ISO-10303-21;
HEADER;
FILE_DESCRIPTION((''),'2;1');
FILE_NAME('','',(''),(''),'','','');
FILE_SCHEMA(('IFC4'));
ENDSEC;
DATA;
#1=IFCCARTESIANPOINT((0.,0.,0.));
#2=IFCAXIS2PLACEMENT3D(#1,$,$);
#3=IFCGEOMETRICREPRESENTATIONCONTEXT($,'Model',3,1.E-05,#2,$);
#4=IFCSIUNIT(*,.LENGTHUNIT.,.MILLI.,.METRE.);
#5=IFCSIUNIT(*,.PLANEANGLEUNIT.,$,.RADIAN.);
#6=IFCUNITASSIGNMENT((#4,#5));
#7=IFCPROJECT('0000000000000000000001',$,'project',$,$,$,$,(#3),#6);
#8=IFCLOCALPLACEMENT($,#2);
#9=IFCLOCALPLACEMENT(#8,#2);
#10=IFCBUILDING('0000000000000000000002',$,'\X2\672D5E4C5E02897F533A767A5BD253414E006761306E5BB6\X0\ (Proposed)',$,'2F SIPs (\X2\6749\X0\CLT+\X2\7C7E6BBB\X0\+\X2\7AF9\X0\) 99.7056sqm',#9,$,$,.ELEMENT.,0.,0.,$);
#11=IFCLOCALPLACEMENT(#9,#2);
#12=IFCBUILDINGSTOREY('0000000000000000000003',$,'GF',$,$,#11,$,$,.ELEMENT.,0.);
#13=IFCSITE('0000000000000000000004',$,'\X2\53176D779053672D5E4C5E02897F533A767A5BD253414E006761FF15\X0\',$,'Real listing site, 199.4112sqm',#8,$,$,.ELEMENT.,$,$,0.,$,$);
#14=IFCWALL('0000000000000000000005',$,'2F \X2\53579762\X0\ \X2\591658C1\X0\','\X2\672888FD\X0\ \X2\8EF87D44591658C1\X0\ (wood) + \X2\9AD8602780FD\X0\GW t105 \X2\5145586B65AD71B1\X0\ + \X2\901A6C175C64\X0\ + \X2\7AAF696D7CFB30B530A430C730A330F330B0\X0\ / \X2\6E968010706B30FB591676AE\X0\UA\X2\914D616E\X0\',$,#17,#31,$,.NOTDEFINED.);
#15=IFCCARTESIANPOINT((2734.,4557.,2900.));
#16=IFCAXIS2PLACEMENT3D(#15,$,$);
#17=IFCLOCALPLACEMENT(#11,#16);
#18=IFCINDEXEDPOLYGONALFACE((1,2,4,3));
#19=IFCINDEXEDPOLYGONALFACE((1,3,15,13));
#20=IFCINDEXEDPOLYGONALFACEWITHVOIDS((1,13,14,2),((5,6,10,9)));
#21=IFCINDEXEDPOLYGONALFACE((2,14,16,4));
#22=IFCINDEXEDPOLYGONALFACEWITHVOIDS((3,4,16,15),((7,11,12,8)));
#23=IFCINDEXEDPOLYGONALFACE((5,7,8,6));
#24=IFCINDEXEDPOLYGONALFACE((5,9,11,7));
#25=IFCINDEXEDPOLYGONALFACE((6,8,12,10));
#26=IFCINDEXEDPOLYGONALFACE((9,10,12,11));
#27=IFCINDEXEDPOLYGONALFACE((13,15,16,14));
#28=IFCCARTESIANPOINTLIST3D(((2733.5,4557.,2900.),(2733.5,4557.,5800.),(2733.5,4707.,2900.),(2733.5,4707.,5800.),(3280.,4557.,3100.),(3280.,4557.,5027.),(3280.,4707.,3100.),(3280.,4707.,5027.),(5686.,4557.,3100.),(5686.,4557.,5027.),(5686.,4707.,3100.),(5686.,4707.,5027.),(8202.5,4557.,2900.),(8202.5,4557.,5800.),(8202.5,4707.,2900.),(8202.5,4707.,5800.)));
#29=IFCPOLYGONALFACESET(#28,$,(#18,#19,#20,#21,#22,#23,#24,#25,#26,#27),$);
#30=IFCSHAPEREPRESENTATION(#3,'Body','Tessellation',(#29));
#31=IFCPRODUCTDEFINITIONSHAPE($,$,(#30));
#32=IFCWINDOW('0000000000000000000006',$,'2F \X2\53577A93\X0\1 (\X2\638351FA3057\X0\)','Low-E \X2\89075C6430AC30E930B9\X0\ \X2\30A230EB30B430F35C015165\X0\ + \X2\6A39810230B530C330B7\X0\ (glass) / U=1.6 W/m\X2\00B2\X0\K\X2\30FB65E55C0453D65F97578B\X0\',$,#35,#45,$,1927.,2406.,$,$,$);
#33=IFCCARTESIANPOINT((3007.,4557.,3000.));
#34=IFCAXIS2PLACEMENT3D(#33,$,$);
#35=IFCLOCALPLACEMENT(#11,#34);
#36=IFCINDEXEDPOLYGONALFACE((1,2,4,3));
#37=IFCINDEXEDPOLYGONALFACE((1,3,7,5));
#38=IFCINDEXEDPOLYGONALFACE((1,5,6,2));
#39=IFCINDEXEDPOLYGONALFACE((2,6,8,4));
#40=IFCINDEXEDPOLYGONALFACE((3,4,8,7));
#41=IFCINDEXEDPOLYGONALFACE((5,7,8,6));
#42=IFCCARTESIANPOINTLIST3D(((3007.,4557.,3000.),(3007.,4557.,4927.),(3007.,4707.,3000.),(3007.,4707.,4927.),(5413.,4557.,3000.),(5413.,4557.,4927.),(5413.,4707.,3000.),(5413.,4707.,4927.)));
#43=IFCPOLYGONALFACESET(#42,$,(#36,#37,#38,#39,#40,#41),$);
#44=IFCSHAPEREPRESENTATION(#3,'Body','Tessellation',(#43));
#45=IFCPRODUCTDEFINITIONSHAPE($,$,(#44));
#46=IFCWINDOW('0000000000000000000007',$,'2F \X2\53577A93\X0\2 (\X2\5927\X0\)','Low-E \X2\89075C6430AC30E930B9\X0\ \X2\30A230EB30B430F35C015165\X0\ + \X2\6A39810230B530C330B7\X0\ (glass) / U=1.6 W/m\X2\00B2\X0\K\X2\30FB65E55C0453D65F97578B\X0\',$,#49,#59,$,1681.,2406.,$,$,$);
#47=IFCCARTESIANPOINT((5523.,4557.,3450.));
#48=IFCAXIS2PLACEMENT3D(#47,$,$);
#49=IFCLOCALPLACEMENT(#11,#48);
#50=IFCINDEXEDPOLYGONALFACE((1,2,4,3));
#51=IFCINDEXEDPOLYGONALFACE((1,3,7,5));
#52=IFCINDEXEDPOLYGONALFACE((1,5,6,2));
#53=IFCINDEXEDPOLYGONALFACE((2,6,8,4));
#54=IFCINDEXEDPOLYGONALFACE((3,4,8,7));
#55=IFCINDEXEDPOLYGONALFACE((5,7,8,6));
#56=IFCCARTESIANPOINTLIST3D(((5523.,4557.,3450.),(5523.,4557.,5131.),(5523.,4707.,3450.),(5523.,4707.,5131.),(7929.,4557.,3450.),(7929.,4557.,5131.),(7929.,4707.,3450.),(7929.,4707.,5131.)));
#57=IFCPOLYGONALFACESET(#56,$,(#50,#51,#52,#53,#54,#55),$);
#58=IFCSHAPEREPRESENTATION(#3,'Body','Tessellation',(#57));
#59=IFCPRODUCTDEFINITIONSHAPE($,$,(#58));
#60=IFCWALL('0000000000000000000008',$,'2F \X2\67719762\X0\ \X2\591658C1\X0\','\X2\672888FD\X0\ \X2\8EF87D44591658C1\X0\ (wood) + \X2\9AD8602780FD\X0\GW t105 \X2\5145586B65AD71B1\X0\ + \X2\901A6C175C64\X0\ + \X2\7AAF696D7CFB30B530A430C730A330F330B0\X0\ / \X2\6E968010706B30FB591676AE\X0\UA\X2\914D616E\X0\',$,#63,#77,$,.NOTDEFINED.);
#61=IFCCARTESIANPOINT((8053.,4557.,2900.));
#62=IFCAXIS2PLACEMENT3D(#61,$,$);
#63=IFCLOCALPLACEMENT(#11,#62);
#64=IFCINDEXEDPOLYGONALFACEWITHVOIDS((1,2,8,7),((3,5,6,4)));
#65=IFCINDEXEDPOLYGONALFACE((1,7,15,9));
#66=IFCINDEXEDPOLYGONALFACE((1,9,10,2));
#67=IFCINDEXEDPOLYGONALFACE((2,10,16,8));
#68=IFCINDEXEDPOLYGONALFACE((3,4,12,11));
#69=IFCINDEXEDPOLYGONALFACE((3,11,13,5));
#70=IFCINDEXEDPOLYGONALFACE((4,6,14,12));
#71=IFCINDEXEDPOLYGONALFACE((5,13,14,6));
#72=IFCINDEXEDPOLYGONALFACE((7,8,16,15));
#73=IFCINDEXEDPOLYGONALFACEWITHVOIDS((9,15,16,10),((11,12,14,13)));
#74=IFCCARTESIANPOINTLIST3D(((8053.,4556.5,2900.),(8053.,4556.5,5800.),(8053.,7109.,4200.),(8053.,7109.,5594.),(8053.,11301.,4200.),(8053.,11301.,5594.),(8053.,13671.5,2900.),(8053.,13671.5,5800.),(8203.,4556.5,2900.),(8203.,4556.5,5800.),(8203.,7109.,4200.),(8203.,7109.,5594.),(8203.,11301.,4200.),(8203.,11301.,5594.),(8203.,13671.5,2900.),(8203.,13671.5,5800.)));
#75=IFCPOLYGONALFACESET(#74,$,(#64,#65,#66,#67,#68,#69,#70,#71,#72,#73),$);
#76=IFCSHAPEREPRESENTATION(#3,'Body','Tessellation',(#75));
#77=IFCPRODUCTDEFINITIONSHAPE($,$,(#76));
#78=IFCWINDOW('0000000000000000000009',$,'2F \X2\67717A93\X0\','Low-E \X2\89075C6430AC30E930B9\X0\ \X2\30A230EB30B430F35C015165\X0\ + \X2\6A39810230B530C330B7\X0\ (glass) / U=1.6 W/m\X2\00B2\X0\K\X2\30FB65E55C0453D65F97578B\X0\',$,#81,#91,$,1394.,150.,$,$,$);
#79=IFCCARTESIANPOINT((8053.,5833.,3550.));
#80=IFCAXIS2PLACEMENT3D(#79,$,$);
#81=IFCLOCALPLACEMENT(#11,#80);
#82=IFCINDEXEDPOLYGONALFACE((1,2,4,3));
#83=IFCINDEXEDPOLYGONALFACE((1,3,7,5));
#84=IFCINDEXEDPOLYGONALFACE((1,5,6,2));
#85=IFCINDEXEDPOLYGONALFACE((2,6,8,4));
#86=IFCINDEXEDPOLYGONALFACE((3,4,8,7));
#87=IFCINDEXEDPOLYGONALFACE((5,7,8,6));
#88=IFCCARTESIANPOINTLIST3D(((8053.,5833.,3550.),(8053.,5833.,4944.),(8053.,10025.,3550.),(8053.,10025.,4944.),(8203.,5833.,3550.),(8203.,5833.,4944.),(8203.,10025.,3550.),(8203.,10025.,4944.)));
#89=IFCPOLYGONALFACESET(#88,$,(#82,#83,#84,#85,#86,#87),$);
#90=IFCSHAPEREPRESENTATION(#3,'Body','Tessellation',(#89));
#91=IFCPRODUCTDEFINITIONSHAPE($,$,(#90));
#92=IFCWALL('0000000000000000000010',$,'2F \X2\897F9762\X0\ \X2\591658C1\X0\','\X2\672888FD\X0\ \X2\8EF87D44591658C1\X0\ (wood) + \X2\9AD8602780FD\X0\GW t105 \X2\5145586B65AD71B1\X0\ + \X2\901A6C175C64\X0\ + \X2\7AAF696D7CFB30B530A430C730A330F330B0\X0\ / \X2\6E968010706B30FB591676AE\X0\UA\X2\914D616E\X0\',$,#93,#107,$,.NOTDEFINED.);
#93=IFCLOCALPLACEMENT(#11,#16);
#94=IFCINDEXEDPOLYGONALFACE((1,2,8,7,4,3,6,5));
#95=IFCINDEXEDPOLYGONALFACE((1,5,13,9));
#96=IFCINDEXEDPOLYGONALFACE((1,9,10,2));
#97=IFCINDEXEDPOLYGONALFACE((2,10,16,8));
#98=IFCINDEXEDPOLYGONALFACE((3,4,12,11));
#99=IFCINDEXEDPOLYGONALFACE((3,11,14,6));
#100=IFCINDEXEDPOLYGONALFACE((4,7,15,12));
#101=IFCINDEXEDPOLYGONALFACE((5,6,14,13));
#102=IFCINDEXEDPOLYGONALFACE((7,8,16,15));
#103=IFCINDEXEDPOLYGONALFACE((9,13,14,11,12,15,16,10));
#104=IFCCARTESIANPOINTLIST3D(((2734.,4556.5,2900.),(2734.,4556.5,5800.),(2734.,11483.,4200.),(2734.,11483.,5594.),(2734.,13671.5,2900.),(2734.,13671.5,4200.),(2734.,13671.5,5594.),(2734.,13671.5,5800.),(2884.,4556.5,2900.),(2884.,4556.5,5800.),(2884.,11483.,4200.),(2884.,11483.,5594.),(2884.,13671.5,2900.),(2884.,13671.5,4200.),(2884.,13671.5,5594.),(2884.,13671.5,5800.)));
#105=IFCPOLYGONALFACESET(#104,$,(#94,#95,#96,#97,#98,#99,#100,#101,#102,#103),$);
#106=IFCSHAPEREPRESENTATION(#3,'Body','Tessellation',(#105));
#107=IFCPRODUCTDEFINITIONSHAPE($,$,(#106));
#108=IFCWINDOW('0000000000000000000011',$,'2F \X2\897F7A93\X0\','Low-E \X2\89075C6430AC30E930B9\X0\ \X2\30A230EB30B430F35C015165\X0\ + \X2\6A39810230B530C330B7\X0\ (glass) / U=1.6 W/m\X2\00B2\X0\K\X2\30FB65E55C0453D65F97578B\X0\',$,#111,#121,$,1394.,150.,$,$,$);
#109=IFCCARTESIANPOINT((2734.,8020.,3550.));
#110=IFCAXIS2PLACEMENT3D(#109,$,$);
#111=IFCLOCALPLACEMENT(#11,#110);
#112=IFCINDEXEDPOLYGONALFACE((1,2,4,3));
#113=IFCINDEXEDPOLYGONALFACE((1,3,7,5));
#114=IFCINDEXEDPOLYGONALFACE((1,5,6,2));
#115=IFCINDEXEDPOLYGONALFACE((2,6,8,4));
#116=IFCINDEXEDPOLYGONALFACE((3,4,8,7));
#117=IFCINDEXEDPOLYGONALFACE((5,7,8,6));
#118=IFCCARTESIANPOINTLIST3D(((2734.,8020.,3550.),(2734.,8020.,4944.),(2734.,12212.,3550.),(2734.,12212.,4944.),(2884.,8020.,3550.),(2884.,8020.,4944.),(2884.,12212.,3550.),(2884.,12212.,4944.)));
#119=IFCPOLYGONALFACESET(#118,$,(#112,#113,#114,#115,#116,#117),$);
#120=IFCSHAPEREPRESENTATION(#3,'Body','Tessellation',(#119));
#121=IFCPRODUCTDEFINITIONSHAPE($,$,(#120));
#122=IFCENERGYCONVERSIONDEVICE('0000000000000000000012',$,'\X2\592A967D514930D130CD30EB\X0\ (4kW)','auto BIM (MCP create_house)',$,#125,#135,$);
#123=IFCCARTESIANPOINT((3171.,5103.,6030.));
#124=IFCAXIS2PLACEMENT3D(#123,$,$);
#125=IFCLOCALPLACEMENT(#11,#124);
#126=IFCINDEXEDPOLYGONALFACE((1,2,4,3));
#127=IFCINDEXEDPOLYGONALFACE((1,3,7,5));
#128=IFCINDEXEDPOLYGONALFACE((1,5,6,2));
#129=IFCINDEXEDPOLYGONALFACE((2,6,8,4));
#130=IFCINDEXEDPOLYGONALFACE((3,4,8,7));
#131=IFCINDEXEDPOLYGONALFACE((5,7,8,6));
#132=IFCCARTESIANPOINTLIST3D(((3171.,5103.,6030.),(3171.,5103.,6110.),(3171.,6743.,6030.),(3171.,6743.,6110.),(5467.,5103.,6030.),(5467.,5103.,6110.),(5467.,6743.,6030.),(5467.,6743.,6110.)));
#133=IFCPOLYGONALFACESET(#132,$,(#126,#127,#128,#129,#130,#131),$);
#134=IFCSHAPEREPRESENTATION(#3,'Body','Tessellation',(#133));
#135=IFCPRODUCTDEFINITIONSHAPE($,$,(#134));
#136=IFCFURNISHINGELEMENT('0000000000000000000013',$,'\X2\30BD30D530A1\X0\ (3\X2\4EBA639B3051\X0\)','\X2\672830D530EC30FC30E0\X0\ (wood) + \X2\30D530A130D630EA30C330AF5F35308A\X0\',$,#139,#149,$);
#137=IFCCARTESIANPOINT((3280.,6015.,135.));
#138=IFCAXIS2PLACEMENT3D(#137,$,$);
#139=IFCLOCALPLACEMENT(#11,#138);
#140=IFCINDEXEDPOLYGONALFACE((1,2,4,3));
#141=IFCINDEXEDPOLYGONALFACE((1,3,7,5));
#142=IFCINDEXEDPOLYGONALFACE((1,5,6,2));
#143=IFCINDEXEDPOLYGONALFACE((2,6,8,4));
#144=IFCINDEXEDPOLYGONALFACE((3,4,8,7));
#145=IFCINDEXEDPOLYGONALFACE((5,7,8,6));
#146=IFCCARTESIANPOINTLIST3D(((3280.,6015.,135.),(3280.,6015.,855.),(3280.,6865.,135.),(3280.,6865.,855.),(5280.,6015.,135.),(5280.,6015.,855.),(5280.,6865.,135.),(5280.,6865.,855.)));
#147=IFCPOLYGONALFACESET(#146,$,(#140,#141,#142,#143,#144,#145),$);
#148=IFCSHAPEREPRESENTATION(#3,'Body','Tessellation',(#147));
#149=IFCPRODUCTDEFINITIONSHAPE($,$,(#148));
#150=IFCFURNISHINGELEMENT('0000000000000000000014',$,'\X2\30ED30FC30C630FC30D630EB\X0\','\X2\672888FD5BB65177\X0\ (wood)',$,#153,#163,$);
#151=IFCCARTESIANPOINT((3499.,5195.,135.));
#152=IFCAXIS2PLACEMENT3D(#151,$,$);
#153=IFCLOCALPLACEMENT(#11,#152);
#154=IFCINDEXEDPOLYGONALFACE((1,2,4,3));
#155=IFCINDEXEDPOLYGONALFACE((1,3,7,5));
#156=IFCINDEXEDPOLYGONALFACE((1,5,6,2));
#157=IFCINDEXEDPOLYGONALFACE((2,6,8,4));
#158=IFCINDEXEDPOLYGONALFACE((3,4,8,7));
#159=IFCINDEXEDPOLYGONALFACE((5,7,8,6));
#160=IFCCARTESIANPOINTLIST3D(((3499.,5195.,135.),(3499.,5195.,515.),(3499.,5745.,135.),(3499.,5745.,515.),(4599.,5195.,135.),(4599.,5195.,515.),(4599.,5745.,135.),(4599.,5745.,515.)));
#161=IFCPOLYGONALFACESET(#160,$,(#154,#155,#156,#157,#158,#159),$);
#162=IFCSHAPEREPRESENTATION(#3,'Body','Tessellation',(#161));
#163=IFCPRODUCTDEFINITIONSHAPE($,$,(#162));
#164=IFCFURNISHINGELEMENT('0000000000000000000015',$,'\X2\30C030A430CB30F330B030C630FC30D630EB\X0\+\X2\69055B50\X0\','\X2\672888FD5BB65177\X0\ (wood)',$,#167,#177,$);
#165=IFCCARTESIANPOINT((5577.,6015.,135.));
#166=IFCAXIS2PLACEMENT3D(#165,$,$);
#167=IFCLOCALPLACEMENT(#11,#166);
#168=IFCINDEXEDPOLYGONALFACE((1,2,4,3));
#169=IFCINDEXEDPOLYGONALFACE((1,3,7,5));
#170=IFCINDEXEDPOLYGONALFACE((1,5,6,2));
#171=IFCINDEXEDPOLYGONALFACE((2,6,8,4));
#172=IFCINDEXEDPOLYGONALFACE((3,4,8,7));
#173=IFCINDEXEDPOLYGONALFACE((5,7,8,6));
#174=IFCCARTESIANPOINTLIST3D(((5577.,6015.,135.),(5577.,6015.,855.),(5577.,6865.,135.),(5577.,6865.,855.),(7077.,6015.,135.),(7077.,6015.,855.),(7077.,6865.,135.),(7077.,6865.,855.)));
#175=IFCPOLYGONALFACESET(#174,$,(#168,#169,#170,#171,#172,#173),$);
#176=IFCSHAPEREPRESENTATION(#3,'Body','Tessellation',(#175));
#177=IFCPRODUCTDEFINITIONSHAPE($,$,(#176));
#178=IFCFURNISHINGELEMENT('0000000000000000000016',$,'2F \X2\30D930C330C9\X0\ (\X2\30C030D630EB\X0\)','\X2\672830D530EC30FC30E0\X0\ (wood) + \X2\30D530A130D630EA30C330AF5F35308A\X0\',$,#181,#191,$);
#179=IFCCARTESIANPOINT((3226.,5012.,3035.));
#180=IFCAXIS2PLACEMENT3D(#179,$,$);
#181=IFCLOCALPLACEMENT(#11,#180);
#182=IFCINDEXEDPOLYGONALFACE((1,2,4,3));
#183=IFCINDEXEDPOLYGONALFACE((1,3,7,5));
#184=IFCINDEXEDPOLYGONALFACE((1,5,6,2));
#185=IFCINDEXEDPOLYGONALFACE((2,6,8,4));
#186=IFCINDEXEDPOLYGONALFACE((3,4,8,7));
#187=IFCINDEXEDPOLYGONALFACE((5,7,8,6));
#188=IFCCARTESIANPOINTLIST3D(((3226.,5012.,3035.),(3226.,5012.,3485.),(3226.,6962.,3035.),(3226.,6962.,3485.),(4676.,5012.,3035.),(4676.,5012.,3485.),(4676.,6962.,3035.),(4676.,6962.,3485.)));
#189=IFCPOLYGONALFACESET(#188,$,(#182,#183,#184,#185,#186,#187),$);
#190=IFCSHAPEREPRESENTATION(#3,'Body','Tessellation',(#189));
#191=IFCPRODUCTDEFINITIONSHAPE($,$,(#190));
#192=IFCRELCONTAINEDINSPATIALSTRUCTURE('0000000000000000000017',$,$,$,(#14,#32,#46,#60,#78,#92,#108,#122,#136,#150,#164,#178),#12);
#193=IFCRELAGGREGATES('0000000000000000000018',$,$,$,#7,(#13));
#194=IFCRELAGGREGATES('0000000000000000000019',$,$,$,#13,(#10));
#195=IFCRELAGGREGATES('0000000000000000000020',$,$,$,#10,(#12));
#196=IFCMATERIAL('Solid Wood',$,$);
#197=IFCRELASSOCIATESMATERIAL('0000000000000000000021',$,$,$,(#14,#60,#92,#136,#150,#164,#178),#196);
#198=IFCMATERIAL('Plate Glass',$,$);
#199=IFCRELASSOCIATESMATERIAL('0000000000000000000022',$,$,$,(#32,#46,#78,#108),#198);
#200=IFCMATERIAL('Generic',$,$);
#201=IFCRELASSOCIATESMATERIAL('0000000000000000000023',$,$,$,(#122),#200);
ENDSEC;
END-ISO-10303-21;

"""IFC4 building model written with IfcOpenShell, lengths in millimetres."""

from ifc_helpers import new_model, si_unit, frame, frame_2d, origin, place, context, project, spatial, rectangle, extrude, material, element, fill, save


model = new_model("IFC4")

# Units and contexts
model_context = context("Model", 3, precision=1e-05, world=origin())
ifc_project = project(units=[si_unit("LENGTHUNIT", "METRE", prefix="MILLI"), si_unit("PLANEANGLEUNIT", "RADIAN")], contexts=[model_context])

# Site, building, storey
site_placement = place(None, origin())
site = spatial("IfcSite", under=ifc_project, at=site_placement, Name="北海道札幌市西区発寒十一条５", ObjectType="Real listing site, 199.4112sqm", CompositionType="ELEMENT", RefElevation=0.0)
building_placement = place(site_placement, origin())
building = spatial("IfcBuilding", under=site, at=building_placement, Name="札幌市西区発寒十一条の家 (Proposed)", ObjectType="2F SIPs (杉CLT+籾殻+竹) 99.7056sqm", CompositionType="ELEMENT", ElevationOfRefHeight=0.0, ElevationOfTerrain=0.0)
storey_placement = place(building_placement, origin())
storey = spatial("IfcBuildingStorey", under=building, at=storey_placement, Name="GF", CompositionType="ELEMENT", Elevation=0.0)

# Shared definitions
ifc_material_1 = material(Name="Solid Wood")

# Wall, openings, windows
wall_1_placement = place(storey_placement, frame((2734.0, 4557.0, 2900.0)))
wall_1 = element("IfcWall", 1, at=wall_1_placement, inside=storey, material=ifc_material_1, Name="2F 南面 外壁", Description="木製 軸組外壁 (wood) + 高性能GW t105 充填断熱 + 通気層 + 窯業系サイディング / 準耐火・外皮UA配慮", PredefinedType="NOTDEFINED", context=model_context, shape_type="SweptSolid", body=[
    extrude(rectangle(XDim=5469.0, YDim=150.0, at=frame_2d((2734.0, 75.0))), frame((2734.0, 4557.0, 2900.0)), (0.0, 0.0, 1.0), 2900.0),
])
opening_1_placement = place(storey_placement, frame((3007.0, 4557.0, 3000.0)))
opening_1 = element("IfcOpeningElement", 2, at=opening_1_placement, cuts=wall_1, PredefinedType="NOTDEFINED", context=model_context, shape_type="SweptSolid", body=[
    extrude(rectangle(XDim=2406.0, YDim=150.0, at=frame_2d((1203.0, 75.0))), frame((3007.0, 4557.0, 3000.0)), (0.0, 0.0, 1.0), 1927.0),
])
opening_2_placement = place(storey_placement, frame((5523.0, 4557.0, 3450.0)))
opening_2 = element("IfcOpeningElement", 3, at=opening_2_placement, cuts=wall_1, PredefinedType="NOTDEFINED", context=model_context, shape_type="SweptSolid", body=[
    extrude(rectangle(XDim=2406.0, YDim=150.0, at=frame_2d((1203.0, 75.0))), frame((5523.0, 4557.0, 3450.0)), (0.0, 0.0, 1.0), 1681.0),
])
ifc_material_2 = material(Name="Plate Glass")
window_1_placement = place(storey_placement, frame((3007.0, 4557.0, 3000.0)))
window_1 = element("IfcWindow", 4, at=window_1_placement, inside=storey, material=ifc_material_2, Name="2F 南窓1 (掃出し)", Description="Low-E 複層ガラス アルゴン封入 + 樹脂サッシ (glass) / U=1.6 W/m²K・日射取得型", OverallHeight=1927.0, OverallWidth=2406.0, context=model_context, shape_type="SweptSolid", body=[
    extrude(rectangle(XDim=2406.0, YDim=150.0, at=frame_2d((1203.0, 75.0))), frame((3007.0, 4557.0, 3000.0)), (0.0, 0.0, 1.0), 1927.0),
])
fill(opening_1, window_1)
window_2_placement = place(storey_placement, frame((5523.0, 4557.0, 3450.0)))
window_2 = element("IfcWindow", 5, at=window_2_placement, inside=storey, material=ifc_material_2, Name="2F 南窓2 (大)", Description="Low-E 複層ガラス アルゴン封入 + 樹脂サッシ (glass) / U=1.6 W/m²K・日射取得型", OverallHeight=1681.0, OverallWidth=2406.0, context=model_context, shape_type="SweptSolid", body=[
    extrude(rectangle(XDim=2406.0, YDim=150.0, at=frame_2d((1203.0, 75.0))), frame((5523.0, 4557.0, 3450.0)), (0.0, 0.0, 1.0), 1681.0),
])
fill(opening_2, window_2)

# Walls, openings, windows
wall_2_placement = place(storey_placement, frame((8053.0, 4557.0, 2900.0)))
wall_2 = element("IfcWall", 6, at=wall_2_placement, inside=storey, material=ifc_material_1, Name="2F 東面 外壁", Description="木製 軸組外壁 (wood) + 高性能GW t105 充填断熱 + 通気層 + 窯業系サイディング / 準耐火・外皮UA配慮", PredefinedType="NOTDEFINED", context=model_context, shape_type="SweptSolid", body=[
    extrude(rectangle(XDim=150.0, YDim=9115.0, at=frame_2d((75.0, 4557.0))), frame((8053.0, 4557.0, 2900.0)), (0.0, 0.0, 1.0), 2900.0),
])
opening_3_placement = place(storey_placement, frame((8053.0, 5833.0, 3550.0)))
opening_3 = element("IfcOpeningElement", 7, at=opening_3_placement, cuts=wall_2, PredefinedType="NOTDEFINED", context=model_context, shape_type="SweptSolid", body=[
    extrude(rectangle(XDim=150.0, YDim=4192.0, at=frame_2d((75.0, 2096.0))), frame((8053.0, 5833.0, 3550.0)), (0.0, 0.0, 1.0), 1394.0),
])
window_3_placement = place(storey_placement, frame((8053.0, 5833.0, 3550.0)))
window_3 = element("IfcWindow", 8, at=window_3_placement, inside=storey, material=ifc_material_2, Name="2F 東窓", Description="Low-E 複層ガラス アルゴン封入 + 樹脂サッシ (glass) / U=1.6 W/m²K・日射取得型", OverallHeight=1394.0, OverallWidth=150.0, context=model_context, shape_type="SweptSolid", body=[
    extrude(rectangle(XDim=150.0, YDim=4192.0, at=frame_2d((75.0, 2096.0))), frame((8053.0, 5833.0, 3550.0)), (0.0, 0.0, 1.0), 1394.0),
])
fill(opening_3, window_3)
wall_3_placement = place(storey_placement, frame((2734.0, 4557.0, 2900.0)))
wall_3 = element("IfcWall", 9, at=wall_3_placement, inside=storey, material=ifc_material_1, Name="2F 西面 外壁", Description="木製 軸組外壁 (wood) + 高性能GW t105 充填断熱 + 通気層 + 窯業系サイディング / 準耐火・外皮UA配慮", PredefinedType="NOTDEFINED", context=model_context, shape_type="SweptSolid", body=[
    extrude(rectangle(XDim=150.0, YDim=9115.0, at=frame_2d((75.0, 4557.0))), frame((2734.0, 4557.0, 2900.0)), (0.0, 0.0, 1.0), 2900.0),
])
opening_4_placement = place(storey_placement, frame((2734.0, 8020.0, 3550.0)))
opening_4 = element("IfcOpeningElement", 10, at=opening_4_placement, cuts=wall_3, PredefinedType="NOTDEFINED", context=model_context, shape_type="SweptSolid", body=[
    extrude(rectangle(XDim=150.0, YDim=4192.0, at=frame_2d((75.0, 2096.0))), frame((2734.0, 8020.0, 3550.0)), (0.0, 0.0, 1.0), 1394.0),
])
window_4_placement = place(storey_placement, frame((2734.0, 8020.0, 3550.0)))
window_4 = element("IfcWindow", 11, at=window_4_placement, inside=storey, material=ifc_material_2, Name="2F 西窓", Description="Low-E 複層ガラス アルゴン封入 + 樹脂サッシ (glass) / U=1.6 W/m²K・日射取得型", OverallHeight=1394.0, OverallWidth=150.0, context=model_context, shape_type="SweptSolid", body=[
    extrude(rectangle(XDim=150.0, YDim=4192.0, at=frame_2d((75.0, 2096.0))), frame((2734.0, 8020.0, 3550.0)), (0.0, 0.0, 1.0), 1394.0),
])
fill(opening_4, window_4)

# Shared definitions
ifc_material_3 = material(Name="Generic")

# Energy conversion device
energy_conversion_device_placement = place(storey_placement, frame((3171.0, 5103.0, 6030.0)))
element("IfcEnergyConversionDevice", 12, at=energy_conversion_device_placement, inside=storey, material=ifc_material_3, Name="太陽光パネル (4kW)", Description="auto BIM (MCP create_house)", context=model_context, shape_type="SweptSolid", body=[
    extrude(rectangle(XDim=2296.0, YDim=1640.0, at=frame_2d((1148.0, 820.0))), frame((3171.0, 5103.0, 6030.0)), (0.0, 0.0, 1.0), 80.0),
])

# Furnishing elements
furnishing_1_placement = place(storey_placement, frame((3280.0, 6015.0, 135.0)))
element("IfcFurnishingElement", 13, at=furnishing_1_placement, inside=storey, material=ifc_material_1, Name="ソファ (3人掛け)", Description="木フレーム (wood) + ファブリック張り", context=model_context, shape_type="SweptSolid", body=[
    extrude(rectangle(XDim=2000.0, YDim=850.0, at=frame_2d((1000.0, 425.0))), frame((3280.0, 6015.0, 135.0)), (0.0, 0.0, 1.0), 720.0),
])
furnishing_2_placement = place(storey_placement, frame((3499.0, 5195.0, 135.0)))
element("IfcFurnishingElement", 14, at=furnishing_2_placement, inside=storey, material=ifc_material_1, Name="ローテーブル", Description="木製家具 (wood)", context=model_context, shape_type="SweptSolid", body=[
    extrude(rectangle(XDim=1100.0, YDim=550.0, at=frame_2d((550.0, 275.0))), frame((3499.0, 5195.0, 135.0)), (0.0, 0.0, 1.0), 380.0),
])
furnishing_3_placement = place(storey_placement, frame((5577.0, 6015.0, 135.0)))
element("IfcFurnishingElement", 15, at=furnishing_3_placement, inside=storey, material=ifc_material_1, Name="ダイニングテーブル+椅子", Description="木製家具 (wood)", context=model_context, shape_type="SweptSolid", body=[
    extrude(rectangle(XDim=1500.0, YDim=850.0, at=frame_2d((750.0, 425.0))), frame((5577.0, 6015.0, 135.0)), (0.0, 0.0, 1.0), 720.0),
])
furnishing_4_placement = place(storey_placement, frame((3226.0, 5012.0, 3035.0)))
element("IfcFurnishingElement", 16, at=furnishing_4_placement, inside=storey, material=ifc_material_1, Name="2F ベッド (ダブル)", Description="木フレーム (wood) + ファブリック張り", context=model_context, shape_type="SweptSolid", body=[
    extrude(rectangle(XDim=1450.0, YDim=1950.0, at=frame_2d((725.0, 975.0))), frame((3226.0, 5012.0, 3035.0)), (0.0, 0.0, 1.0), 450.0),
])

save(model, "model.ifc")
